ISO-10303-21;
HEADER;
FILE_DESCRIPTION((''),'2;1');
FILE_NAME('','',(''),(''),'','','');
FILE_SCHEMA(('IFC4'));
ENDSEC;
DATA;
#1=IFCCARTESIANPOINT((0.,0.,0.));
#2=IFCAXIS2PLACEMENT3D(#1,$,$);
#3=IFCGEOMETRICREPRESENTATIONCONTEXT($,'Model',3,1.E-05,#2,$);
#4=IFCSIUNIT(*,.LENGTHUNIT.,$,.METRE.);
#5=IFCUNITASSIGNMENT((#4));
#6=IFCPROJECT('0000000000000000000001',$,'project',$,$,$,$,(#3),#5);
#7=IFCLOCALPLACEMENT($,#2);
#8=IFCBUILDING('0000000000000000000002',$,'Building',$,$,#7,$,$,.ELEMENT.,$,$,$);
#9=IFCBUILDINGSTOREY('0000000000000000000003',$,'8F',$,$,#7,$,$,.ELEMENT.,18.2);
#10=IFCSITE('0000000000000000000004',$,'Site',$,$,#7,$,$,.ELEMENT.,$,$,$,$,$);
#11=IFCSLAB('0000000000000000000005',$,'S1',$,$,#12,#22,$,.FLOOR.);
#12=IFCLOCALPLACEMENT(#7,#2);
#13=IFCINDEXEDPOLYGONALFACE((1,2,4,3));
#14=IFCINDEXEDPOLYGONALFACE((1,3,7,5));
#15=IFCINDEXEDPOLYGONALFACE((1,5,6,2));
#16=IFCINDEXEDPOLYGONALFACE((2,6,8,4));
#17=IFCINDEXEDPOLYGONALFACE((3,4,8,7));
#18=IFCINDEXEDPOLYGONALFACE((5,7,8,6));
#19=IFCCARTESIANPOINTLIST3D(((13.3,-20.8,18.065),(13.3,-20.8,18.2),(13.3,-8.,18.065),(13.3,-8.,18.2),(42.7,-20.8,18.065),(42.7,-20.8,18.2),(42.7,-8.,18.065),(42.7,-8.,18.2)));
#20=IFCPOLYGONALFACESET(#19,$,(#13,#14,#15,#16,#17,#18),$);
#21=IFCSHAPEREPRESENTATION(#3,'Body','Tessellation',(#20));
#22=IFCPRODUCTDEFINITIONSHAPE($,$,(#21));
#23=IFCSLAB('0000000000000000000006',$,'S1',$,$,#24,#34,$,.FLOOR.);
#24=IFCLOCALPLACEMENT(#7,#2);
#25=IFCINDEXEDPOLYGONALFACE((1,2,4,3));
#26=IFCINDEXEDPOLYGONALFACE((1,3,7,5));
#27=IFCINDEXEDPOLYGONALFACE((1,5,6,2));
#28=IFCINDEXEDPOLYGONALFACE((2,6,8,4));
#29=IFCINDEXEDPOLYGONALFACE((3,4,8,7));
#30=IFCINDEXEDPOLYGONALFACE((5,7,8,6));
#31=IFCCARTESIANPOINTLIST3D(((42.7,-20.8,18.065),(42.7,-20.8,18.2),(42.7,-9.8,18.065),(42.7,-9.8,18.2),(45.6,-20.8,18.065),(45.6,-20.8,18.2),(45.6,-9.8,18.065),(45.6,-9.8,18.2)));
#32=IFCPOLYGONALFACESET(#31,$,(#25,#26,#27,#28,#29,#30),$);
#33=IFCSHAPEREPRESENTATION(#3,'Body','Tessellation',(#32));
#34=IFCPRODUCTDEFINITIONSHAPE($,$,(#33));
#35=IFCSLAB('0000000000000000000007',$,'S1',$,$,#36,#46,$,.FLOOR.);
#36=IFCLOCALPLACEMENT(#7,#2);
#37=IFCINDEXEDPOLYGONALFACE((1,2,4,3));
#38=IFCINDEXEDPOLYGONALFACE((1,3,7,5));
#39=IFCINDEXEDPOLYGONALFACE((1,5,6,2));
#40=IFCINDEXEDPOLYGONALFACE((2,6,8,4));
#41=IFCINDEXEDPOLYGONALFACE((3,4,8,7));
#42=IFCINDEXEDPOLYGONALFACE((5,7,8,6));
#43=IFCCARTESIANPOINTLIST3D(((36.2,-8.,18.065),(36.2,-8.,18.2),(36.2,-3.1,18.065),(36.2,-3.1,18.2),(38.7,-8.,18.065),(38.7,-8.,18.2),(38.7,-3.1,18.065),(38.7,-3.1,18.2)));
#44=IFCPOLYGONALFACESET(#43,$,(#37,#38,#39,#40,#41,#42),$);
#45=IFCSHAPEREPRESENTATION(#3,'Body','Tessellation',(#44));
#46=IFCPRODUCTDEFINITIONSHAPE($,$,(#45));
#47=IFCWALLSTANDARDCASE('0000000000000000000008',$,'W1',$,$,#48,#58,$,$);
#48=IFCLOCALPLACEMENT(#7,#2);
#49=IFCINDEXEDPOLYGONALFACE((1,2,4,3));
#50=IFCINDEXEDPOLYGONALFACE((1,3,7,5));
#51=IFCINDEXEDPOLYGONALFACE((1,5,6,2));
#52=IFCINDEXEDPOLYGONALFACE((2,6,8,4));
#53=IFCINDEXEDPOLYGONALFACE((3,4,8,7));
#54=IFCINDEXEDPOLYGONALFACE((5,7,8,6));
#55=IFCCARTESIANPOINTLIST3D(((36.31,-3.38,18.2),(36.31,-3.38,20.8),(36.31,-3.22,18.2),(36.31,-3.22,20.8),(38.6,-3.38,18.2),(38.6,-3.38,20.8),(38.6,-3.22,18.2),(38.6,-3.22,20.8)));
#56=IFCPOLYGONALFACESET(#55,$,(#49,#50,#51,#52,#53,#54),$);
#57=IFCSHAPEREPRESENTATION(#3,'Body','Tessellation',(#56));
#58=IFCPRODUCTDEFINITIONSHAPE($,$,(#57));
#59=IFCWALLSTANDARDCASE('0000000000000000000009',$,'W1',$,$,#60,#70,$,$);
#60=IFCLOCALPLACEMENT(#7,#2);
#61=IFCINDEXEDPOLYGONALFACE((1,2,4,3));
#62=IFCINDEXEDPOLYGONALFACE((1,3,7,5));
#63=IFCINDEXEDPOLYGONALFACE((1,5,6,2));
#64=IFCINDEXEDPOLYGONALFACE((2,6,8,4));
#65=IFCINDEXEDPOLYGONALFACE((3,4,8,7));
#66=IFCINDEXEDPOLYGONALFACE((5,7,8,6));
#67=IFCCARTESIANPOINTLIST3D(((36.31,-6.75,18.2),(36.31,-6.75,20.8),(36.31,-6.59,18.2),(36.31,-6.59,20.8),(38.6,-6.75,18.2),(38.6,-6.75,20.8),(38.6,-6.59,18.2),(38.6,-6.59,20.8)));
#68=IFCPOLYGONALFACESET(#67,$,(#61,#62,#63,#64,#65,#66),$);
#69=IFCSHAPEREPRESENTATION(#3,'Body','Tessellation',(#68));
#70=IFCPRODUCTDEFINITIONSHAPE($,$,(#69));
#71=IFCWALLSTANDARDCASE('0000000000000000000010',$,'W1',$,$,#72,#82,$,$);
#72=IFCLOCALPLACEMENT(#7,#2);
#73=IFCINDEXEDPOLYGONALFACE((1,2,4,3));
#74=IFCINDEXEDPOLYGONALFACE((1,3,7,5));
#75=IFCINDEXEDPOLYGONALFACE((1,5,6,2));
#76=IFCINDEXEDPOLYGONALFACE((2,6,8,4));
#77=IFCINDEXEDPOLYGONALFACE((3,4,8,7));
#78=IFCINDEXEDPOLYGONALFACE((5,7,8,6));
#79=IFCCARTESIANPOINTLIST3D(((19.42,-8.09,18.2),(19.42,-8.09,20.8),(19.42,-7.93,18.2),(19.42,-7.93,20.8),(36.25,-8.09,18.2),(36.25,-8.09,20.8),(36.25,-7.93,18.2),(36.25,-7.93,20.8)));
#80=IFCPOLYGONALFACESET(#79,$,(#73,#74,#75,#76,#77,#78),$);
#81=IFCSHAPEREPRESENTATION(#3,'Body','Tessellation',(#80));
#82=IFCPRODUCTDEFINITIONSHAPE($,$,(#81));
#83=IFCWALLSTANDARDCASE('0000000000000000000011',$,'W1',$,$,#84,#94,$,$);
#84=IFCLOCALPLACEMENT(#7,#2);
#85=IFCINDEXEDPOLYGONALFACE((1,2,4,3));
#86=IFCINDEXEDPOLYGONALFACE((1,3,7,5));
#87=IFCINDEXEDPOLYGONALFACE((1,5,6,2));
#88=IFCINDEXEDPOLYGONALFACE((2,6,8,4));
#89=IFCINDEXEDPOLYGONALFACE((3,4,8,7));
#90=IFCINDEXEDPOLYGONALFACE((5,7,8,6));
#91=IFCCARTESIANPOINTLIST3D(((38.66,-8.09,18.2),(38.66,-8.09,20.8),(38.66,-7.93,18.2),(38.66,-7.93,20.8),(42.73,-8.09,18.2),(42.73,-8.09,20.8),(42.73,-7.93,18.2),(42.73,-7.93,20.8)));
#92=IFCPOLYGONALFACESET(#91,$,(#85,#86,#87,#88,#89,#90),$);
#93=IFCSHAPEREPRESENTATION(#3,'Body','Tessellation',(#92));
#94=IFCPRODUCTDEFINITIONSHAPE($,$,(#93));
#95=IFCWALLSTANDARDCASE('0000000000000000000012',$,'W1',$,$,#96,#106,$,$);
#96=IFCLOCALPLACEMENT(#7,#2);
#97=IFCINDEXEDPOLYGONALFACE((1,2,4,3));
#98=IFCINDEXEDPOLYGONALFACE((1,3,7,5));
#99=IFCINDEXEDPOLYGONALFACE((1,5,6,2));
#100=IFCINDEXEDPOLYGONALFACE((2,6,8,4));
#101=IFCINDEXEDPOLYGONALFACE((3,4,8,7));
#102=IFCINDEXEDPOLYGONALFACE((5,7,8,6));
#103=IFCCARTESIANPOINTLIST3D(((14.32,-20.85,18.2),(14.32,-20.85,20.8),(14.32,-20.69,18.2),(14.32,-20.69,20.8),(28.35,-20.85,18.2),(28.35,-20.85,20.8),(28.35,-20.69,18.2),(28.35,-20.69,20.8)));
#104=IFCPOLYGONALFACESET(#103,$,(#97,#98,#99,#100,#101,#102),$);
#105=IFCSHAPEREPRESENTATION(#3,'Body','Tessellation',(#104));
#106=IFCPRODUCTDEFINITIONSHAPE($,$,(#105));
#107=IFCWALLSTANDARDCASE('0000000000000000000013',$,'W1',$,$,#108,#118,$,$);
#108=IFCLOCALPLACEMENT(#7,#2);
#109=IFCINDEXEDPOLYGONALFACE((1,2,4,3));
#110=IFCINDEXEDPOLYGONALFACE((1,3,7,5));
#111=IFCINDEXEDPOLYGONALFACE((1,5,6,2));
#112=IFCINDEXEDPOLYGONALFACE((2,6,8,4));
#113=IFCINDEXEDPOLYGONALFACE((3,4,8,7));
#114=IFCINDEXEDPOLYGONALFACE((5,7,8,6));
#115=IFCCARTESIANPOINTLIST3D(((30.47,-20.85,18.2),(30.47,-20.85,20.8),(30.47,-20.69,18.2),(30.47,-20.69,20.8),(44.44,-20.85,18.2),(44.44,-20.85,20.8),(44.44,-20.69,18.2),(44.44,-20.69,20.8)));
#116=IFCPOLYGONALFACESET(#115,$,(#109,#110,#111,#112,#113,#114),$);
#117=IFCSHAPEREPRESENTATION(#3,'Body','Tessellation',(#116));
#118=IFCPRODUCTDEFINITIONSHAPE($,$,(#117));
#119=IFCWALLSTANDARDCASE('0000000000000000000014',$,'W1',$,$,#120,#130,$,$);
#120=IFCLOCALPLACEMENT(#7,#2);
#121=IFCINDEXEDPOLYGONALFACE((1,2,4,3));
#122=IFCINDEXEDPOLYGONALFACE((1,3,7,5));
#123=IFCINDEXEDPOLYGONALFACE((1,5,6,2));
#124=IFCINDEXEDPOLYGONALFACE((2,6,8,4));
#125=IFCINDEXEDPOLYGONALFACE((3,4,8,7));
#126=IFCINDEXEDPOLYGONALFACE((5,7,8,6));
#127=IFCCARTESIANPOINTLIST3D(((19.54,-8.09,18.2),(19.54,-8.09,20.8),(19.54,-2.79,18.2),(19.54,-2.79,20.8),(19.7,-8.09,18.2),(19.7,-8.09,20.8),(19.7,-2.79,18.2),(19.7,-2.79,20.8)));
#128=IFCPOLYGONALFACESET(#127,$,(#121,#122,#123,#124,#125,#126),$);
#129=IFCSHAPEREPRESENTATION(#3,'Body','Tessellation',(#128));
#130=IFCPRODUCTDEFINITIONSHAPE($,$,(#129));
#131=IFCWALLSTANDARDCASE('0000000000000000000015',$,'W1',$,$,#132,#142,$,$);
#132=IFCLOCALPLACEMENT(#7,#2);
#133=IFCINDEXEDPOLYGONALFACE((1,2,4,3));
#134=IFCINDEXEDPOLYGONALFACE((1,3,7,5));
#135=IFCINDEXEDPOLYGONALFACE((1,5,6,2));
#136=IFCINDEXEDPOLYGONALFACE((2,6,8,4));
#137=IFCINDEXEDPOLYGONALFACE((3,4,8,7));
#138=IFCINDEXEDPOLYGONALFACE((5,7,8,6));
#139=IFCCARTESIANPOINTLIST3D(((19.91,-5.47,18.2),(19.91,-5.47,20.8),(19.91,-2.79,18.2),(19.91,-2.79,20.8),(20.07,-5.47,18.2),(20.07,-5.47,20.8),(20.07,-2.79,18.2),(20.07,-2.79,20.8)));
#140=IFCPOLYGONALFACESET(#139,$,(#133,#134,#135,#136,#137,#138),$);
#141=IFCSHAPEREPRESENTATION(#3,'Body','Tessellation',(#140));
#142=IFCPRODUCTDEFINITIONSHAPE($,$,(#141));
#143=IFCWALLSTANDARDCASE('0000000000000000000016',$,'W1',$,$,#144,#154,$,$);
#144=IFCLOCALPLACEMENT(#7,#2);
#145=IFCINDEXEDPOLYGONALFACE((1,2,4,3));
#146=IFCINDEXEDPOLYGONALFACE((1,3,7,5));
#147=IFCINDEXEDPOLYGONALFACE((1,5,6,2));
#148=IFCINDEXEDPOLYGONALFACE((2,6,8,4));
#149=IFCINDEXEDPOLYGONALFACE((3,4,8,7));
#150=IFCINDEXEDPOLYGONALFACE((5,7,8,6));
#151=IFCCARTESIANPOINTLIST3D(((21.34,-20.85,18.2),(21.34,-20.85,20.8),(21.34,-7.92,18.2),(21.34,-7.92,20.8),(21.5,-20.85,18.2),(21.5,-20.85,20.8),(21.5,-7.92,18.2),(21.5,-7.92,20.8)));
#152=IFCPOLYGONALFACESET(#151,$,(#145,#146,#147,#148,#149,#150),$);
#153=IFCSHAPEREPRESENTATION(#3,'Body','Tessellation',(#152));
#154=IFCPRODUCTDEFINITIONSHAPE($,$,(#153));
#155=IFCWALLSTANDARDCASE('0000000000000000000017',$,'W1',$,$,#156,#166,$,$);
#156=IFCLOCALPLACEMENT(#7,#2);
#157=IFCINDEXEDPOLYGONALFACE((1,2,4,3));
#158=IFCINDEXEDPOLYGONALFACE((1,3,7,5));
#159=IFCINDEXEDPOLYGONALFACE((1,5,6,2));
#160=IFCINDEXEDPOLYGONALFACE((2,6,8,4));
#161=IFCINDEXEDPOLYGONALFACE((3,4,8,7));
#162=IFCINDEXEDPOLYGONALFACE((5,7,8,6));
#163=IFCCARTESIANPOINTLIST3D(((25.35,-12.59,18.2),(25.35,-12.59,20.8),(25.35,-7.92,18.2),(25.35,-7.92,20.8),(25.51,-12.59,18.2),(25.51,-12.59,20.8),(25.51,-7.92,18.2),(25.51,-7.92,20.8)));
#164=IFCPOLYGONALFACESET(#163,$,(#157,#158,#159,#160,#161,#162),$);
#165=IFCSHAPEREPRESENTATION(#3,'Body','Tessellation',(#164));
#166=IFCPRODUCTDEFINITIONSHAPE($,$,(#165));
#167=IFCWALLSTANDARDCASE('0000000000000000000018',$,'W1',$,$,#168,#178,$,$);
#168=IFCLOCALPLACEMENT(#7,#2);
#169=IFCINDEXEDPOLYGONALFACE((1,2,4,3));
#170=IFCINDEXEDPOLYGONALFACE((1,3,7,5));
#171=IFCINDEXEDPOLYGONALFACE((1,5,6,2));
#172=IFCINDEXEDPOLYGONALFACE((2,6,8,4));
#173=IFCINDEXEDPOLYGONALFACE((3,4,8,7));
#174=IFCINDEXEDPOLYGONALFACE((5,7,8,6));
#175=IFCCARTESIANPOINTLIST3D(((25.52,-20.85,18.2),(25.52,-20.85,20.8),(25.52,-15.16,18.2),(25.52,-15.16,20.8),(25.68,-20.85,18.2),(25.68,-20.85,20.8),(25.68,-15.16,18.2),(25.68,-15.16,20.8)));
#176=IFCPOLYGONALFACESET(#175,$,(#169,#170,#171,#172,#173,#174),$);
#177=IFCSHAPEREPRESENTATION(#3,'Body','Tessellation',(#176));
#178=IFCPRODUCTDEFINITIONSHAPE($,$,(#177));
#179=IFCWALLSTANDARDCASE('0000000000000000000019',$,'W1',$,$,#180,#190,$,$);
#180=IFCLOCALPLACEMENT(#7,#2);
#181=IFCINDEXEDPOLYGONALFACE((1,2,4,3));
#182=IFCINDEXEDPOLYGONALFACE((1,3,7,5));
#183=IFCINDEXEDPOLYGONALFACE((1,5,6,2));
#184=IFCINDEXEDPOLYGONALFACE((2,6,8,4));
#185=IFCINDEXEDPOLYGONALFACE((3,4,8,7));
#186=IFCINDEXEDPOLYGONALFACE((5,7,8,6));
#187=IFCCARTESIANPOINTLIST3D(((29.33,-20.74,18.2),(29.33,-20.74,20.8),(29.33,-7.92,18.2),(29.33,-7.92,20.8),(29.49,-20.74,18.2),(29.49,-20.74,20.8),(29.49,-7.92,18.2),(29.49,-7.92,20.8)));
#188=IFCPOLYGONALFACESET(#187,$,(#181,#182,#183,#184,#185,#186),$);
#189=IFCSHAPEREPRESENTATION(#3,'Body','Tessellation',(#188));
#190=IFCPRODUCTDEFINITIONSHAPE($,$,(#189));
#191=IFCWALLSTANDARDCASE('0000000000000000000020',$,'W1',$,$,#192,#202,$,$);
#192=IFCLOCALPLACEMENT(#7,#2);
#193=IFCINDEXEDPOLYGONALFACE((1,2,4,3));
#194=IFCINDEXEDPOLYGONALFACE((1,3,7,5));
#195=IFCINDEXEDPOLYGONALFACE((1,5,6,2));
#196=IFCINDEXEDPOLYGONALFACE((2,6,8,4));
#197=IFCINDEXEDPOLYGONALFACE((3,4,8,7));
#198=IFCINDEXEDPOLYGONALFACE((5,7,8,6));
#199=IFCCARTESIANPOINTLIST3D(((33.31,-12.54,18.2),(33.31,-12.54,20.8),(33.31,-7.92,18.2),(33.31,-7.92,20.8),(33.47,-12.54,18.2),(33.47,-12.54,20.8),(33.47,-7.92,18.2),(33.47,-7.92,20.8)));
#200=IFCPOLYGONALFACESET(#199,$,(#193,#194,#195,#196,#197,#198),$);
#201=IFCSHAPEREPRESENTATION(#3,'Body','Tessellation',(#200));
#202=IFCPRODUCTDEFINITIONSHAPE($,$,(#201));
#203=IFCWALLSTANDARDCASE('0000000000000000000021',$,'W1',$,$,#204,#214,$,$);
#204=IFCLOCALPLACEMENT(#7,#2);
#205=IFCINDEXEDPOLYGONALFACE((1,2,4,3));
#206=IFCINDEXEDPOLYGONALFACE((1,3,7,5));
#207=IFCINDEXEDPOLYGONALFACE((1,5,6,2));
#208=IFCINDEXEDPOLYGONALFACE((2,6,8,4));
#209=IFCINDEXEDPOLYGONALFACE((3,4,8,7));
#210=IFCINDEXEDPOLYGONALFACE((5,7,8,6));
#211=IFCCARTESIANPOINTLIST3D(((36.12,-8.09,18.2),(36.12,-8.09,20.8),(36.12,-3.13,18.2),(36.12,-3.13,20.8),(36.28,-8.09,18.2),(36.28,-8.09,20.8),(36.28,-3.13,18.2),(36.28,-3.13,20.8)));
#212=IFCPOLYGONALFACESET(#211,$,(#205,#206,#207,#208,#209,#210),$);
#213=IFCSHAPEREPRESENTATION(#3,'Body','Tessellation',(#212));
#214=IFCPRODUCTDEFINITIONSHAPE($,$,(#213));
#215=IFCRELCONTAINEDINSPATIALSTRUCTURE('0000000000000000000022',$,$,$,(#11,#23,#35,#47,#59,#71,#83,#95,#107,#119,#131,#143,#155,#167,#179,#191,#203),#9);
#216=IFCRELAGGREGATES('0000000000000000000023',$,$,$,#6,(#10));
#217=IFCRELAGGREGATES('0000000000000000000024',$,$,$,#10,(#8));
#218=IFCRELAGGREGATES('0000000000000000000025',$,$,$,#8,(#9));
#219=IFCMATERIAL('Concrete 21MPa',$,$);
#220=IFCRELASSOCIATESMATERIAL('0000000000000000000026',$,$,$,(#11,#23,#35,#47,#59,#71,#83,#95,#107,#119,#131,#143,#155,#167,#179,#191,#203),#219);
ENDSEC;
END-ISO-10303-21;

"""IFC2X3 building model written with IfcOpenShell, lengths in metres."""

from ifc_helpers import new_model, si_unit, frame, origin, origin_2d, place, context, project, spatial, rectangle, extrude, material, element, save


model = new_model("IFC2X3")

# Units and contexts
model_context = context("Model", 3, precision=1e-05, world=origin())
ifc_project = project(units=[si_unit("LENGTHUNIT", "METRE")], contexts=[model_context])

# Site, building, storey
placement = place(None, origin())
site = spatial("IfcSite", under=ifc_project, at=placement, Name="Site", CompositionType="ELEMENT")
building = spatial("IfcBuilding", under=site, at=placement, Name="Building", CompositionType="ELEMENT")
storey = spatial("IfcBuildingStorey", under=building, at=placement, Name="8F", CompositionType="ELEMENT", Elevation=18.2)

# Slabs
ifc_material_1 = material(Name="Concrete 21MPa")
slab_1_placement = place(None, frame((28.0, -14.4, 18.065)))
element("IfcSlab", 1, at=slab_1_placement, inside=storey, material=ifc_material_1, Name="S1", PredefinedType="FLOOR", context=model_context, shape_type="SweptSolid", body=[
    extrude(rectangle(XDim=29.4, YDim=12.8, at=origin_2d()), origin(), (0.0, 0.0, 1.0), 0.135),
])
slab_2_placement = place(None, frame((44.15, -15.3, 18.065)))
element("IfcSlab", 2, at=slab_2_placement, inside=storey, material=ifc_material_1, Name="S1", PredefinedType="FLOOR", context=model_context, shape_type="SweptSolid", body=[
    extrude(rectangle(XDim=2.9, YDim=11.0, at=origin_2d()), origin(), (0.0, 0.0, 1.0), 0.135),
])
slab_3_placement = place(None, frame((37.45, -5.55, 18.065)))
element("IfcSlab", 3, at=slab_3_placement, inside=storey, material=ifc_material_1, Name="S1", PredefinedType="FLOOR", context=model_context, shape_type="SweptSolid", body=[
    extrude(rectangle(XDim=2.5, YDim=4.9, at=origin_2d()), origin(), (0.0, 0.0, 1.0), 0.135),
])

# Walls
for number, where, name in (
    (4, (37.455, -3.3, 18.2), "W1"),
    (5, (37.455, -6.67, 18.2), "W1"),
):
    element("IfcWallStandardCase", number, at=place(None, frame(where)), inside=storey, material=ifc_material_1, Name=name, context=model_context, shape_type="SweptSolid", body=[
        extrude(rectangle(XDim=2.29, YDim=0.16, at=origin_2d()), origin(), (0.0, 0.0, 1.0), 2.6),
    ])
wall_1_placement = place(None, frame((27.835, -8.01, 18.2)))
element("IfcWallStandardCase", 6, at=wall_1_placement, inside=storey, material=ifc_material_1, Name="W1", context=model_context, shape_type="SweptSolid", body=[
    extrude(rectangle(XDim=16.83, YDim=0.16, at=origin_2d()), origin(), (0.0, 0.0, 1.0), 2.6),
])
wall_2_placement = place(None, frame((40.695, -8.01, 18.2)))
element("IfcWallStandardCase", 7, at=wall_2_placement, inside=storey, material=ifc_material_1, Name="W1", context=model_context, shape_type="SweptSolid", body=[
    extrude(rectangle(XDim=4.07, YDim=0.16, at=origin_2d()), origin(), (0.0, 0.0, 1.0), 2.6),
])
wall_3_placement = place(None, frame((21.335, -20.77, 18.2)))
element("IfcWallStandardCase", 8, at=wall_3_placement, inside=storey, material=ifc_material_1, Name="W1", context=model_context, shape_type="SweptSolid", body=[
    extrude(rectangle(XDim=14.03, YDim=0.16, at=origin_2d()), origin(), (0.0, 0.0, 1.0), 2.6),
])
wall_4_placement = place(None, frame((37.455, -20.77, 18.2)))
element("IfcWallStandardCase", 9, at=wall_4_placement, inside=storey, material=ifc_material_1, Name="W1", context=model_context, shape_type="SweptSolid", body=[
    extrude(rectangle(XDim=13.97, YDim=0.16, at=origin_2d()), origin(), (0.0, 0.0, 1.0), 2.6),
])
wall_5_placement = place(None, frame((19.62, -5.44, 18.2)))
element("IfcWallStandardCase", 10, at=wall_5_placement, inside=storey, material=ifc_material_1, Name="W1", context=model_context, shape_type="SweptSolid", body=[
    extrude(rectangle(XDim=0.16, YDim=5.3, at=origin_2d()), origin(), (0.0, 0.0, 1.0), 2.6),
])
wall_6_placement = place(None, frame((19.99, -4.13, 18.2)))
element("IfcWallStandardCase", 11, at=wall_6_placement, inside=storey, material=ifc_material_1, Name="W1", context=model_context, shape_type="SweptSolid", body=[
    extrude(rectangle(XDim=0.16, YDim=2.68, at=origin_2d()), origin(), (0.0, 0.0, 1.0), 2.6),
])
wall_7_placement = place(None, frame((21.42, -14.385, 18.2)))
element("IfcWallStandardCase", 12, at=wall_7_placement, inside=storey, material=ifc_material_1, Name="W1", context=model_context, shape_type="SweptSolid", body=[
    extrude(rectangle(XDim=0.16, YDim=12.93, at=origin_2d()), origin(), (0.0, 0.0, 1.0), 2.6),
])
wall_8_placement = place(None, frame((25.43, -10.255, 18.2)))
element("IfcWallStandardCase", 13, at=wall_8_placement, inside=storey, material=ifc_material_1, Name="W1", context=model_context, shape_type="SweptSolid", body=[
    extrude(rectangle(XDim=0.16, YDim=4.67, at=origin_2d()), origin(), (0.0, 0.0, 1.0), 2.6),
])
wall_9_placement = place(None, frame((25.6, -18.005, 18.2)))
element("IfcWallStandardCase", 14, at=wall_9_placement, inside=storey, material=ifc_material_1, Name="W1", context=model_context, shape_type="SweptSolid", body=[
    extrude(rectangle(XDim=0.16, YDim=5.69, at=origin_2d()), origin(), (0.0, 0.0, 1.0), 2.6),
])
wall_10_placement = place(None, frame((29.41, -14.33, 18.2)))
element("IfcWallStandardCase", 15, at=wall_10_placement, inside=storey, material=ifc_material_1, Name="W1", context=model_context, shape_type="SweptSolid", body=[
    extrude(rectangle(XDim=0.16, YDim=12.82, at=origin_2d()), origin(), (0.0, 0.0, 1.0), 2.6),
])
wall_11_placement = place(None, frame((33.39, -10.23, 18.2)))
element("IfcWallStandardCase", 16, at=wall_11_placement, inside=storey, material=ifc_material_1, Name="W1", context=model_context, shape_type="SweptSolid", body=[
    extrude(rectangle(XDim=0.16, YDim=4.62, at=origin_2d()), origin(), (0.0, 0.0, 1.0), 2.6),
])
wall_12_placement = place(None, frame((36.2, -5.61, 18.2)))
element("IfcWallStandardCase", 17, at=wall_12_placement, inside=storey, material=ifc_material_1, Name="W1", context=model_context, shape_type="SweptSolid", body=[
    extrude(rectangle(XDim=0.16, YDim=4.96, at=origin_2d()), origin(), (0.0, 0.0, 1.0), 2.6),
])

save(model, "model.ifc")
